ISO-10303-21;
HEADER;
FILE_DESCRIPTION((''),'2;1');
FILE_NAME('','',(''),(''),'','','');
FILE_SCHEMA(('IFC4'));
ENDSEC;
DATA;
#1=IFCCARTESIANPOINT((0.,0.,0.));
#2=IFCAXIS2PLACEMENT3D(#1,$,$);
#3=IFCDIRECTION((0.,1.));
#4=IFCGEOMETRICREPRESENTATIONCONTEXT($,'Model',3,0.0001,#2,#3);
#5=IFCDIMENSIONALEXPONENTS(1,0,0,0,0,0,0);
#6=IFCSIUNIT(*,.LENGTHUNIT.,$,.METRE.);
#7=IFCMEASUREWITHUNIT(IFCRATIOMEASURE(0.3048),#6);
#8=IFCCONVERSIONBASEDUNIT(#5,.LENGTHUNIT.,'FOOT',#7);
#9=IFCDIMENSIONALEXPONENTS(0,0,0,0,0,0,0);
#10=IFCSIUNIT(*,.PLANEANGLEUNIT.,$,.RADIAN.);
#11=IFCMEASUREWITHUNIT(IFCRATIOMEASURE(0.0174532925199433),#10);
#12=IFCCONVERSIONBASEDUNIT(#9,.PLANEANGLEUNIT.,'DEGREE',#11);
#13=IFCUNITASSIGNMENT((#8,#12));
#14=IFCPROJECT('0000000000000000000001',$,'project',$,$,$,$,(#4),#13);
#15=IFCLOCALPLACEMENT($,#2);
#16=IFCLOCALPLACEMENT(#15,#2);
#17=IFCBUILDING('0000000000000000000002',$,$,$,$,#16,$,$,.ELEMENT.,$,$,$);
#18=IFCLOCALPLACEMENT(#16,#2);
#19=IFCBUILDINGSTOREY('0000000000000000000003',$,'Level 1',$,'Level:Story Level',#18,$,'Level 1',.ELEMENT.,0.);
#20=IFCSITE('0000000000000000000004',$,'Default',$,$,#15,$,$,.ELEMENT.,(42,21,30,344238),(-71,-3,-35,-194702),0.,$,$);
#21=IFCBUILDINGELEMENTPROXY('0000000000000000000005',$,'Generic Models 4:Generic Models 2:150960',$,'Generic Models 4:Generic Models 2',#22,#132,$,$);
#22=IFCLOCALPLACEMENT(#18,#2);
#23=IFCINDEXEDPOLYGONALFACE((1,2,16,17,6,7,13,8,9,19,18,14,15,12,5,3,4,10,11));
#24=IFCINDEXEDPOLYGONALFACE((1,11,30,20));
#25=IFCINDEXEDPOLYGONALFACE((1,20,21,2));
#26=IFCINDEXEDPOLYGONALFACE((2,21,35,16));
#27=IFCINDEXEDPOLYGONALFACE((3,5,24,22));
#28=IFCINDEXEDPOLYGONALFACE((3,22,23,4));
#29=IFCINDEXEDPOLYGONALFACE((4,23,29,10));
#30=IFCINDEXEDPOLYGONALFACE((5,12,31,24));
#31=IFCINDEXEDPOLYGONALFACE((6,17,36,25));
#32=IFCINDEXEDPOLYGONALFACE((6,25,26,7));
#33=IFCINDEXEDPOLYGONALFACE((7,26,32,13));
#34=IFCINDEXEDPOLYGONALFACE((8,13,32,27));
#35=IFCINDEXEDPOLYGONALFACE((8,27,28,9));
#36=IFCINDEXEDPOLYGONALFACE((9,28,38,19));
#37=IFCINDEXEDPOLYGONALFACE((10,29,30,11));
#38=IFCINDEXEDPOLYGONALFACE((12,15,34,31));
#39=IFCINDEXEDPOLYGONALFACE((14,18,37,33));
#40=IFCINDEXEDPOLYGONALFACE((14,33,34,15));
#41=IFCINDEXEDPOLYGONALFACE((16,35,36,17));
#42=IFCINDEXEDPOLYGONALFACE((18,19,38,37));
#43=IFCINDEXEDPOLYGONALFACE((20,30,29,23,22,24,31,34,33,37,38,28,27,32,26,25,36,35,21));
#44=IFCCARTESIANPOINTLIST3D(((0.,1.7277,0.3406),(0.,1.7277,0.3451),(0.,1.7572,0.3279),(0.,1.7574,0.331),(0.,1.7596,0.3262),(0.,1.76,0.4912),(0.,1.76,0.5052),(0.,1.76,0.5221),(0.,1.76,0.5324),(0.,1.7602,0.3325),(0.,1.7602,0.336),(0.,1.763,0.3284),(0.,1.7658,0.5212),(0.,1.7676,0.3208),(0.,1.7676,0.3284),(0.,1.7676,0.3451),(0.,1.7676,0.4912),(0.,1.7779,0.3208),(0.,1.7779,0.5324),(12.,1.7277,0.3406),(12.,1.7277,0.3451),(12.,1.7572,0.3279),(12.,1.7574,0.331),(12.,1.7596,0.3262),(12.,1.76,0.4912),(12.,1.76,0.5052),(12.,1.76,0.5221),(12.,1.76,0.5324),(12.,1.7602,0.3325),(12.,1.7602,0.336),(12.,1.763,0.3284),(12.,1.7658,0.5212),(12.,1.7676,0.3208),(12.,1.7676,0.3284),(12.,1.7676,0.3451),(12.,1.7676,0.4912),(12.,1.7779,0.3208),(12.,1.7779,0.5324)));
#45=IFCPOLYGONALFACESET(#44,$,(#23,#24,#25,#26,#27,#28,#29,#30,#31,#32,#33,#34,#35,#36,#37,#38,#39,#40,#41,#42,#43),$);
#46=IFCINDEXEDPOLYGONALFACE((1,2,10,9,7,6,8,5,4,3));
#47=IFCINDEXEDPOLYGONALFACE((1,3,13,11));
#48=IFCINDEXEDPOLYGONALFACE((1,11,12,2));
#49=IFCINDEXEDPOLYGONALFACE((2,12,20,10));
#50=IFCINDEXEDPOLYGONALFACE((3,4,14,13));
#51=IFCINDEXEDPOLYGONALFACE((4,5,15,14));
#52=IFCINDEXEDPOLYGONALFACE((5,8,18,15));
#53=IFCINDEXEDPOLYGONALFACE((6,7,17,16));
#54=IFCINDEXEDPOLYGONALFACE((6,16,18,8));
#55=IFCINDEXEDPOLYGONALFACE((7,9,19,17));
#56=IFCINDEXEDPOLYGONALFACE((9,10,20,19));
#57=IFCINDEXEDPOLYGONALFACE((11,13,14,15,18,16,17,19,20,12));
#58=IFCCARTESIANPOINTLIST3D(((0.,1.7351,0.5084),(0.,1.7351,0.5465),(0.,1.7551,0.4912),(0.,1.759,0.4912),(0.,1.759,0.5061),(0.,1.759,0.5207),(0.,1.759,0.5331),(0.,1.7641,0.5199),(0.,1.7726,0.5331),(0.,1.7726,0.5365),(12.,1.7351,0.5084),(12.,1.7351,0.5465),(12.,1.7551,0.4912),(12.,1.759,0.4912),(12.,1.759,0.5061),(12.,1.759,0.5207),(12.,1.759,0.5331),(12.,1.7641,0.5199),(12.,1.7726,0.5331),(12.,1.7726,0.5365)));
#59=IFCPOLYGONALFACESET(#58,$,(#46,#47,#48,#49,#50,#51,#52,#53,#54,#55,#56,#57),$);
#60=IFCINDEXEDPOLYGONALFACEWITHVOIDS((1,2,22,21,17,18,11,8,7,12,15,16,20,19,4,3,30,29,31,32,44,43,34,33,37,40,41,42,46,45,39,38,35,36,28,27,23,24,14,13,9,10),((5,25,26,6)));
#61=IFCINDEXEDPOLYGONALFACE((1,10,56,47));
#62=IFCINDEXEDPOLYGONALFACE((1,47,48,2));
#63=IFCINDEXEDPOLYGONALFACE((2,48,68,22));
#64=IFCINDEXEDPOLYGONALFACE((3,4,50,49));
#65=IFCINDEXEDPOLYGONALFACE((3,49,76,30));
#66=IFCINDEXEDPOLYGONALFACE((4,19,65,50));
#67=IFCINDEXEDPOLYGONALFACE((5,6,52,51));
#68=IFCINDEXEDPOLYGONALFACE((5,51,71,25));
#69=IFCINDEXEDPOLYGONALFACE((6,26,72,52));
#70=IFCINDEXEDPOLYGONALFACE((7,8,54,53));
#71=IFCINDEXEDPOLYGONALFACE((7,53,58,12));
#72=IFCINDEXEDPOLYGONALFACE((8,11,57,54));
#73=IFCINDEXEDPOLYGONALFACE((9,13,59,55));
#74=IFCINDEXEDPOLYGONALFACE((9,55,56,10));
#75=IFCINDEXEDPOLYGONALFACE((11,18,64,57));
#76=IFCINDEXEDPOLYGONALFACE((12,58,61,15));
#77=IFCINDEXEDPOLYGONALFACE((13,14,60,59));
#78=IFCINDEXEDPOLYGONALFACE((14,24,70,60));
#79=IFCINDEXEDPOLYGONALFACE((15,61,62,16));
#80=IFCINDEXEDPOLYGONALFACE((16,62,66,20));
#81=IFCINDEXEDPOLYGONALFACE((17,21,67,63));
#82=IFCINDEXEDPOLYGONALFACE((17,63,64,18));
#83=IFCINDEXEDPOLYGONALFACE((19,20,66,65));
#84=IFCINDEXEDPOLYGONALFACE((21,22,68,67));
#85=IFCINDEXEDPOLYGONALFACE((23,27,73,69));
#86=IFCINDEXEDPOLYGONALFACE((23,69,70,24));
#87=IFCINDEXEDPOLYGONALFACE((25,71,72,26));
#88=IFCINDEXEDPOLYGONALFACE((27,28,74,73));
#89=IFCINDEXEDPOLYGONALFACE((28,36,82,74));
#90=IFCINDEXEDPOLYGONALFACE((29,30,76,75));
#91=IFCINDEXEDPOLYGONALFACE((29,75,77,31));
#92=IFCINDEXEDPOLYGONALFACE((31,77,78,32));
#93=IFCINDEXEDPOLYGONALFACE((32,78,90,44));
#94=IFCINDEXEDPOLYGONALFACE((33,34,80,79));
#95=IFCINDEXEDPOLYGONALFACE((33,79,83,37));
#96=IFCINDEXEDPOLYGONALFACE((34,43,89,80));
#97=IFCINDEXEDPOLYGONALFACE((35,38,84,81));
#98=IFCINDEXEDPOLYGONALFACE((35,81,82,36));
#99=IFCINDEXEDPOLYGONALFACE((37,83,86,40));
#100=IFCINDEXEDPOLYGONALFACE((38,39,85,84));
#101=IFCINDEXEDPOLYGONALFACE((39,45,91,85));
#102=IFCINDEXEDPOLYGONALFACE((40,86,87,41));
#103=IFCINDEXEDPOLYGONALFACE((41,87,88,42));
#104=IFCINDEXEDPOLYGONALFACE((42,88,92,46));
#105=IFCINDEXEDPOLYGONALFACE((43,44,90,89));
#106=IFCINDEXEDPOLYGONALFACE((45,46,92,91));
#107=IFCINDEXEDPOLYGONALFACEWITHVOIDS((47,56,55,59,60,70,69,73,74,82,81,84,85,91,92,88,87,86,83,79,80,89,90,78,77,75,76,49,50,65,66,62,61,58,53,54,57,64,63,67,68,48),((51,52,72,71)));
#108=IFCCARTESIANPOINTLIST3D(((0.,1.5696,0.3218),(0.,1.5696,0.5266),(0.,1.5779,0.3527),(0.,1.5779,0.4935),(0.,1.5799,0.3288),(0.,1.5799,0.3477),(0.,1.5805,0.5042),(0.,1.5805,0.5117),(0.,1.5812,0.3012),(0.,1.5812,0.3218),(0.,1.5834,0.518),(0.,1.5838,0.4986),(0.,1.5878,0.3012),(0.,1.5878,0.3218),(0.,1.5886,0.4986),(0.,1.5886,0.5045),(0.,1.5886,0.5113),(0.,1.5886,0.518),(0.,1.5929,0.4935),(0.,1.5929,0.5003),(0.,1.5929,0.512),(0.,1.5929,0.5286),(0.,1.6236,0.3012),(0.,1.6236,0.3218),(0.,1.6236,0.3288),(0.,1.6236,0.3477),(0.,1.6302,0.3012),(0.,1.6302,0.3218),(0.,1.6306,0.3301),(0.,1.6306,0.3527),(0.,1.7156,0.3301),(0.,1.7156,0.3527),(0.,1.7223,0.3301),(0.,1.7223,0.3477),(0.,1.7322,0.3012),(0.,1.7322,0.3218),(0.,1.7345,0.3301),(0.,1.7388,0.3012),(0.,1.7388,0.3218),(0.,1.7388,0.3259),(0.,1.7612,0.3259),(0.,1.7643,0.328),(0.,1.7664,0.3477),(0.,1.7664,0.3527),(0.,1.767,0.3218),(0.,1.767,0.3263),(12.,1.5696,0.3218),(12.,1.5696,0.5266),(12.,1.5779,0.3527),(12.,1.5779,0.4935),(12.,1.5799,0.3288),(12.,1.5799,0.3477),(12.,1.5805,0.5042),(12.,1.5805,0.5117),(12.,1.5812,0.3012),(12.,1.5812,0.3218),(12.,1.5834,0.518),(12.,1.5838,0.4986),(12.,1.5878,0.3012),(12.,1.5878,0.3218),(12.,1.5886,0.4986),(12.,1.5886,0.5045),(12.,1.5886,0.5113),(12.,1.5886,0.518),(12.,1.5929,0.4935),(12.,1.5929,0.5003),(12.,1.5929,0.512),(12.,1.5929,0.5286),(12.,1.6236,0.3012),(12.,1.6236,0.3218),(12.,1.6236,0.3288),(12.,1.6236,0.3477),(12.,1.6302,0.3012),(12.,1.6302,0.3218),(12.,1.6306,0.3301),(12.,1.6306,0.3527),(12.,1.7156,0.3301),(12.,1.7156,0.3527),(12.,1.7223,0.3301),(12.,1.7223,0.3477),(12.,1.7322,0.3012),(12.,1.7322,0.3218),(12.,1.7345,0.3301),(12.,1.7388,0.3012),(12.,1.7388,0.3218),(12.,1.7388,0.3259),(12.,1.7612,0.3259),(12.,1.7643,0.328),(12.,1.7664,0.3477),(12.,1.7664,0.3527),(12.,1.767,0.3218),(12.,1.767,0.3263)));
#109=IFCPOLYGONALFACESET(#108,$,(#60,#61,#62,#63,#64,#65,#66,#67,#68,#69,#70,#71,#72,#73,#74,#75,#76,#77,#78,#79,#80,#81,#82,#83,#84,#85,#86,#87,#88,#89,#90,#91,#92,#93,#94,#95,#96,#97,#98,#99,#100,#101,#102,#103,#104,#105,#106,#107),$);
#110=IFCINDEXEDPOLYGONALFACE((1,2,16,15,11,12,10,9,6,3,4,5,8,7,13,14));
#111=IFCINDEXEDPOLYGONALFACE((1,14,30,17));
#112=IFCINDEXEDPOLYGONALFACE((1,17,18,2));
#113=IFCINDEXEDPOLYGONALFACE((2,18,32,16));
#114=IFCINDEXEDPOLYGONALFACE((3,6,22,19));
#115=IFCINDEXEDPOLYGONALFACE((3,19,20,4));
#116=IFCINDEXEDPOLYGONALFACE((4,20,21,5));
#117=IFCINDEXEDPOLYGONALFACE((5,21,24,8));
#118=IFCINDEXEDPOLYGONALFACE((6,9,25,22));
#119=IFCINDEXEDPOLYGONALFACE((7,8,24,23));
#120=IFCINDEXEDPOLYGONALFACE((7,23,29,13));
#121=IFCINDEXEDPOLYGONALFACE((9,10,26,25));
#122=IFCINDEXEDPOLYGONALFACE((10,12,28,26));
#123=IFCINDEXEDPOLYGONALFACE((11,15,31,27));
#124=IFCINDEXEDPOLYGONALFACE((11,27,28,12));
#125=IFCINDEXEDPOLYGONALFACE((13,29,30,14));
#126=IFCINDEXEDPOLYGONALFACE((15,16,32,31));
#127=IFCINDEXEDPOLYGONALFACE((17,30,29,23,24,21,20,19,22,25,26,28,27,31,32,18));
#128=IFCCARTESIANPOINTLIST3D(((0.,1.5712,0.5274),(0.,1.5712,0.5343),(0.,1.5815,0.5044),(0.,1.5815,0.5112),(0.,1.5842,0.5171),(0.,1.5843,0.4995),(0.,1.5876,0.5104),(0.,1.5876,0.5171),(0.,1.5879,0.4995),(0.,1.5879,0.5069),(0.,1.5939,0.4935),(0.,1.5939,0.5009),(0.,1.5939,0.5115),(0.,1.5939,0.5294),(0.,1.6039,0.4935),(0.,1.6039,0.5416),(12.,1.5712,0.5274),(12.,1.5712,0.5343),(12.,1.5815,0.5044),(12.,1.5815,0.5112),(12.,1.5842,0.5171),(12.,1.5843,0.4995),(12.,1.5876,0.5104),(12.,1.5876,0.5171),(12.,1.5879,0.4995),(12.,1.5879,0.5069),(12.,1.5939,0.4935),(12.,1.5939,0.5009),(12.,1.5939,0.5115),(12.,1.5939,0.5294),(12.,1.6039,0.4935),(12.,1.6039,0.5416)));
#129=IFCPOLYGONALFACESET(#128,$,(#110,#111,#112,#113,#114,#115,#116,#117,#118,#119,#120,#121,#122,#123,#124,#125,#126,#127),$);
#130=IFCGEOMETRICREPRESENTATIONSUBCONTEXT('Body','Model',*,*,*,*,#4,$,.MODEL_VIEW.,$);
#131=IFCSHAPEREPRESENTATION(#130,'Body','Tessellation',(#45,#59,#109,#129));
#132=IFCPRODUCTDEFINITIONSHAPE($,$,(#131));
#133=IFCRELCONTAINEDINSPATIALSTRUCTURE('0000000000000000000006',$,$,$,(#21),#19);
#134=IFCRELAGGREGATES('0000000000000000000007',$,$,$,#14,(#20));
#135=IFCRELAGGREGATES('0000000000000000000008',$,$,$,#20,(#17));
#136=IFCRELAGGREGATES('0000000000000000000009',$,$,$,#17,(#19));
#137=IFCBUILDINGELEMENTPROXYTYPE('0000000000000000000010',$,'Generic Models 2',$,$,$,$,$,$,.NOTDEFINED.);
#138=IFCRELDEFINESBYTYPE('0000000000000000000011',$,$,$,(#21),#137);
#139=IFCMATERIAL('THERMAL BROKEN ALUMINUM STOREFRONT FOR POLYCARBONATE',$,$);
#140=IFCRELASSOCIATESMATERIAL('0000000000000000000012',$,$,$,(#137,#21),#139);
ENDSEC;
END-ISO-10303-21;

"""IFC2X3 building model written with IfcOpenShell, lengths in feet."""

from ifc_helpers import new_model, entity, si_unit, converted_unit, direction, frame, origin, place, context, subcontext, project, spatial, polyline, outline, extrude, source, transform, mapped, material, type_object, type_shapes, element, save


model = new_model("IFC2X3")

# Units and contexts
model_context = context("Model", 3, precision=0.0001, world=origin(), true_north=direction((0.0, 1.0)))
body_context = subcontext(model_context, "Body", "Model", "MODEL_VIEW")
ifc_project = project(units=[converted_unit("LENGTHUNIT", "FOOT", entity("IfcRatioMeasure", 0.3048), si_unit("LENGTHUNIT", "METRE"), dimensions=[1, 0, 0, 0, 0, 0, 0]), converted_unit("PLANEANGLEUNIT", "DEGREE", entity("IfcRatioMeasure", 0.0174532925199433), si_unit("PLANEANGLEUNIT", "RADIAN"), dimensions=[0, 0, 0, 0, 0, 0, 0])], contexts=[model_context])

# Site, building, storey
site_placement = place(None, origin())
site = spatial("IfcSite", under=ifc_project, at=site_placement, Name="Default", CompositionType="ELEMENT", RefLatitude=(42, 21, 30, 344238), RefLongitude=(-71, -3, -35, -194702), RefElevation=0.0)
building_placement = place(site_placement, origin())
building = spatial("IfcBuilding", under=site, at=building_placement, CompositionType="ELEMENT")
storey_placement = place(building_placement, origin())
storey = spatial("IfcBuildingStorey", under=building, at=storey_placement, Name="Level 1", ObjectType="Level:Story Level", LongName="Level 1", CompositionType="ELEMENT", Elevation=0.0)

# Building element proxy
ifc_material = material(Name="THERMAL BROKEN ALUMINUM STOREFRONT FOR POLYCARBONATE")
building_element_proxy_type_1 = type_object("IfcBuildingElementProxyType", Name="Generic Models 2", PredefinedType="NOTDEFINED", material=ifc_material)
shared_shape_1 = source(origin(), body_context, "Body", "SweptSolid", [
    extrude(outline(polyline([(0.068, 0.0006), (0.0711, 0.0006), (0.0726, 0.0031), (0.0702, 0.0064), (0.07, 0.011), (0.0776, 0.0114), (0.0771, 0.0217), (-0.1343, 0.0107), (-0.1334, -0.0072), (-0.1231, -0.0066), (-0.1224, -0.0008), (-0.1062, -0.0058), (-0.0922, -0.005), (-0.0926, 0.0025), (0.0533, 0.0101), (0.0554, -0.0297), (0.0599, -0.0295), (0.0628, 0.0032), (0.0663, 0.0034), (0.068, 0.0006)])), frame((-15.0475, 0.32, 0.0977), z_axis=(1.0, 0.0, 0.0), x_axis=(0.0, -0.051774, -0.998659)), (0.0, 0.0, 1.0), 12.0),
    extrude(outline(polyline([(-0.0104, -0.0212), (0.0284, -0.0212), (0.0186, 0.0156), (-0.0052, 0.0271), (-0.009, 0.026), (-0.0051, 0.0117), (-0.0065, -0.003), (-0.0014, -0.0025), (0.0018, -0.0144), (-0.0113, -0.0179), (-0.0104, -0.0212)])), frame((-15.0475, 0.3168, 0.2175), z_axis=(1.0, 0.0, 0.0), x_axis=(0.0, -0.966235, 0.257663)), (0.0, 0.0, 1.0), 12.0),
    extrude(outline(polyline([(-0.073, 0.107), (-0.058, 0.107), (-0.058, 0.1137), (-0.0623, 0.118), (-0.0623, 0.1121), (-0.0672, 0.1121), (-0.0704, 0.1177), (-0.0704, 0.1252), (-0.0675, 0.1315), (-0.0623, 0.1315), (-0.0623, 0.1248), (-0.058, 0.1255), (-0.058, 0.142), (-0.0814, 0.1401), (-0.0814, -0.0647), (-0.0697, -0.0647), (-0.0697, -0.0853), (-0.0631, -0.0853), (-0.0631, -0.0647), (-0.0273, -0.0647), (-0.0273, -0.0853), (-0.0207, -0.0853), (-0.0207, -0.0647), (0.0812, -0.0647), (0.0812, -0.0853), (0.0878, -0.0853), (0.0878, -0.0647), (0.1161, -0.0647), (0.1161, -0.0603), (0.1133, -0.0585), (0.1102, -0.0606), (0.0878, -0.0606), (0.0836, -0.0564), (0.0713, -0.0564), (0.0713, -0.0389), (0.1155, -0.0389), (0.1155, -0.0338), (0.0647, -0.0338), (0.0647, -0.0564), (-0.0203, -0.0564), (-0.0203, -0.0338), (-0.073, -0.0338), (-0.073, 0.107)]), holes=[polyline([(-0.0711, -0.0577), (-0.0711, -0.0389), (-0.0273, -0.0389), (-0.0273, -0.0577), (-0.0711, -0.0577)])]), frame((-15.0475, 0.2107, 0.0853), z_axis=(1.0, 0.0, 0.0), x_axis=(0.0, 1.0, 0.0)), (0.0, 0.0, 1.0), 12.0),
    extrude(outline(polyline([(-0.0218, -0.0251), (0.0116, -0.0251), (0.0131, -0.0183), (-0.0094, -0.0153), (-0.0056, 0.0021), (0.0008, 0.0018), (-0.0006, -0.0047), (0.0027, -0.0054), (0.0066, -0.0003), (0.0081, 0.0064), (0.0064, 0.0118), (0.0029, 0.0126), (0.0013, 0.0053), (-0.0032, 0.0125), (-0.0017, 0.0197), (-0.0114, 0.0218), (-0.0218, -0.0251)])), frame((-15.0475, 0.1478, 0.2112), z_axis=(1.0, 0.0, 0.0), x_axis=(0.0, -0.976068, -0.217466)), (0.0, 0.0, 1.0), 12.0),
])
type_shapes(building_element_proxy_type_1, [shared_shape_1])
proxy_1_placement = place(storey_placement, frame((15.0475, 1.4402, 0.3012)))
element("IfcBuildingElementProxy", 1, at=proxy_1_placement, inside=storey, type_object=building_element_proxy_type_1, material=ifc_material, Name="Generic Models 4:Generic Models 2:150960", ObjectType="Generic Models 4:Generic Models 2", context=body_context, shape_type="MappedRepresentation", body=[
    mapped(shared_shape_1, transform((0.0, 0.0, 0.0), scale=1.0)),
])

save(model, "model.ifc")
